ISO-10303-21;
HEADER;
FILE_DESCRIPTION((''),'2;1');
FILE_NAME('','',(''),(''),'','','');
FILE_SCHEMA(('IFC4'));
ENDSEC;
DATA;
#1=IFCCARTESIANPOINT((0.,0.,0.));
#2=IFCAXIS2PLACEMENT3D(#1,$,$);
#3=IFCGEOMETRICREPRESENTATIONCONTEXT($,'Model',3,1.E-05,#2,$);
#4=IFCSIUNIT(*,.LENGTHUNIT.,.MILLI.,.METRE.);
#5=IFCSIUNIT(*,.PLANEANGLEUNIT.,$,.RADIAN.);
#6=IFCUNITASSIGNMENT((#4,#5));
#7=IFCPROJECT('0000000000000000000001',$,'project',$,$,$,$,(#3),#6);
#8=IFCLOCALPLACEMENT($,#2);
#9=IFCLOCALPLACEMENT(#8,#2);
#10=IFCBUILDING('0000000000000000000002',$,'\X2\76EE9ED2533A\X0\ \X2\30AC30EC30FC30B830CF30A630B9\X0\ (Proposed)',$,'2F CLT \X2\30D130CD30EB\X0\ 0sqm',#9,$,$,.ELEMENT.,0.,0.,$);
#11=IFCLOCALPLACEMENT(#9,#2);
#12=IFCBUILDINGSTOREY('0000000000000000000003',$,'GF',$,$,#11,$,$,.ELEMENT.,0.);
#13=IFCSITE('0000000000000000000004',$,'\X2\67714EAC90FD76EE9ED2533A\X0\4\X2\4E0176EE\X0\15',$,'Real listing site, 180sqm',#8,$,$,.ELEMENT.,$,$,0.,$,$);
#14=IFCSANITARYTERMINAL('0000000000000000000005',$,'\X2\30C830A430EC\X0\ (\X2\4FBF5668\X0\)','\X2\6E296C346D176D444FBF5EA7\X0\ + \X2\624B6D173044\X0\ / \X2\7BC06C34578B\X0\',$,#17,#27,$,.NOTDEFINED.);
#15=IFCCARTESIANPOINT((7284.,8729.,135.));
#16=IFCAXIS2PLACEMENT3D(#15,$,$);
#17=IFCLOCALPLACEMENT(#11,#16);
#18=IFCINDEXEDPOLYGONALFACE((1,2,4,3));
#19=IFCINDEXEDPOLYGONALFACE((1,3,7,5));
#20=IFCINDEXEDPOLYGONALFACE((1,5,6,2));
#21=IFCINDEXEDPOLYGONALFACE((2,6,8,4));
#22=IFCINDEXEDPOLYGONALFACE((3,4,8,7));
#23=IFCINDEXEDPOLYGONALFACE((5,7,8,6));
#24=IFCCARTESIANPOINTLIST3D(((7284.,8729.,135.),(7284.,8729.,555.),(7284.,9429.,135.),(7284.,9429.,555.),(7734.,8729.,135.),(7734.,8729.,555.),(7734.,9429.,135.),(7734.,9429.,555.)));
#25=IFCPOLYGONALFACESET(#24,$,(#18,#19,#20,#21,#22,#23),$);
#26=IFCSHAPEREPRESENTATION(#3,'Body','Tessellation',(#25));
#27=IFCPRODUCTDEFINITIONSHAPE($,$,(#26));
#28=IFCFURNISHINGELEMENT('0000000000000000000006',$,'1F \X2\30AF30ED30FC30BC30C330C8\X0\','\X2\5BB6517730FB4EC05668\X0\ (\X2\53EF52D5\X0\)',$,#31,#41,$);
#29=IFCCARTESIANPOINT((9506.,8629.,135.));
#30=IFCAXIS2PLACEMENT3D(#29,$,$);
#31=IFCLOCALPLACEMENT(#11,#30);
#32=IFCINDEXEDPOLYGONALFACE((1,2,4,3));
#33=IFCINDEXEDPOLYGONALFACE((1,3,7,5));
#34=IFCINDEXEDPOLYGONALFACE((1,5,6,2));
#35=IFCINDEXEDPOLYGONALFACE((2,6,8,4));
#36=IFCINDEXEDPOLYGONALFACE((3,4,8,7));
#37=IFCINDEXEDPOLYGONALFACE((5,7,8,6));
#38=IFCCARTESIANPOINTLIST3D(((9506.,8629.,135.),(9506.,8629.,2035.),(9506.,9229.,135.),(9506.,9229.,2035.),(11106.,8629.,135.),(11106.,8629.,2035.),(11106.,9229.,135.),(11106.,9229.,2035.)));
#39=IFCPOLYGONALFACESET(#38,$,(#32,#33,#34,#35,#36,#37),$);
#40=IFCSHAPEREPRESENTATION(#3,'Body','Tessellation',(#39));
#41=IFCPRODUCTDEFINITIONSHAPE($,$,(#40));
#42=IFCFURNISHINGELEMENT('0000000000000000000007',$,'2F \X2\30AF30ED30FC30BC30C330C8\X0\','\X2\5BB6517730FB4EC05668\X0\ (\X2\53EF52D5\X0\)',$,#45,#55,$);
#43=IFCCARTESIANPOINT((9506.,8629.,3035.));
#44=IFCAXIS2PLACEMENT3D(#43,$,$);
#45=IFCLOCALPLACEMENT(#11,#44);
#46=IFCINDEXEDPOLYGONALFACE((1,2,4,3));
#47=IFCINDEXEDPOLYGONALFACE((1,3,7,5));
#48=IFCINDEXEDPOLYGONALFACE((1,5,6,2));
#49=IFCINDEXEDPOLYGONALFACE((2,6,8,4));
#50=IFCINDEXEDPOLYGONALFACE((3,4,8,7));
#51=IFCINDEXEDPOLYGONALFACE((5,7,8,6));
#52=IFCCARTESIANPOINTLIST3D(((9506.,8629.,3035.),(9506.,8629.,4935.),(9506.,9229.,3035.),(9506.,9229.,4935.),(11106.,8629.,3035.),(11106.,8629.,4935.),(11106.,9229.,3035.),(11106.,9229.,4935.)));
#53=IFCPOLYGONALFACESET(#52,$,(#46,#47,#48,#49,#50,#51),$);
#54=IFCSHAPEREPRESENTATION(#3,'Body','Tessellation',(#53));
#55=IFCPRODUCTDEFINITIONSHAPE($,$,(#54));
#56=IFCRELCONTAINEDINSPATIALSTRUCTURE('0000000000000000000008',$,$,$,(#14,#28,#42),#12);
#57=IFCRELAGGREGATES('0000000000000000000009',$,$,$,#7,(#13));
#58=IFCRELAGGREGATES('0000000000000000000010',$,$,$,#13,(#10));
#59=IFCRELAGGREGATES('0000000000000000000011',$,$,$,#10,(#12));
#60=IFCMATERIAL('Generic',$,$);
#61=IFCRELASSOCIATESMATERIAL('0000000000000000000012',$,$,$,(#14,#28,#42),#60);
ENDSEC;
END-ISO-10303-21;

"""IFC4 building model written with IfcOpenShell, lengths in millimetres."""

from ifc_helpers import new_model, si_unit, frame, frame_2d, origin, place, context, project, spatial, rectangle, extrude, material, element, save


model = new_model("IFC4")

# Units and contexts
model_context = context("Model", 3, precision=1e-05, world=origin())
ifc_project = project(units=[si_unit("LENGTHUNIT", "METRE", prefix="MILLI"), si_unit("PLANEANGLEUNIT", "RADIAN")], contexts=[model_context])

# Site, building, storey
site_placement = place(None, origin())
site = spatial("IfcSite", under=ifc_project, at=site_placement, Name="東京都目黒区4丁目15", ObjectType="Real listing site, 180sqm", CompositionType="ELEMENT", RefElevation=0.0)
building_placement = place(site_placement, origin())
building = spatial("IfcBuilding", under=site, at=building_placement, Name="目黒区 ガレージハウス (Proposed)", ObjectType="2F CLT パネル 0sqm", CompositionType="ELEMENT", ElevationOfRefHeight=0.0, ElevationOfTerrain=0.0)
storey_placement = place(building_placement, origin())
storey = spatial("IfcBuildingStorey", under=building, at=storey_placement, Name="GF", CompositionType="ELEMENT", Elevation=0.0)

# Shared definitions
ifc_material_1 = material(Name="Generic")

# Sanitary terminal
sanitary_terminal_1_placement = place(storey_placement, frame((7284.0, 8729.0, 135.0)))
element("IfcSanitaryTerminal", 1, at=sanitary_terminal_1_placement, inside=storey, material=ifc_material_1, Name="トイレ (便器)", Description="温水洗浄便座 + 手洗い / 節水型", PredefinedType="NOTDEFINED", context=model_context, shape_type="SweptSolid", body=[
    extrude(rectangle(XDim=450.0, YDim=700.0, at=frame_2d((225.0, 350.0))), frame((7284.0, 8729.0, 135.0)), (0.0, 0.0, 1.0), 420.0),
])

# Furnishing elements
furnishing_1_placement = place(storey_placement, frame((9506.0, 8629.0, 135.0)))
element("IfcFurnishingElement", 2, at=furnishing_1_placement, inside=storey, material=ifc_material_1, Name="1F クローゼット", Description="家具・什器 (可動)", context=model_context, shape_type="SweptSolid", body=[
    extrude(rectangle(XDim=1600.0, YDim=600.0, at=frame_2d((800.0, 300.0))), frame((9506.0, 8629.0, 135.0)), (0.0, 0.0, 1.0), 1900.0),
])
furnishing_2_placement = place(storey_placement, frame((9506.0, 8629.0, 3035.0)))
element("IfcFurnishingElement", 3, at=furnishing_2_placement, inside=storey, material=ifc_material_1, Name="2F クローゼット", Description="家具・什器 (可動)", context=model_context, shape_type="SweptSolid", body=[
    extrude(rectangle(XDim=1600.0, YDim=600.0, at=frame_2d((800.0, 300.0))), frame((9506.0, 8629.0, 3035.0)), (0.0, 0.0, 1.0), 1900.0),
])

save(model, "model.ifc")
